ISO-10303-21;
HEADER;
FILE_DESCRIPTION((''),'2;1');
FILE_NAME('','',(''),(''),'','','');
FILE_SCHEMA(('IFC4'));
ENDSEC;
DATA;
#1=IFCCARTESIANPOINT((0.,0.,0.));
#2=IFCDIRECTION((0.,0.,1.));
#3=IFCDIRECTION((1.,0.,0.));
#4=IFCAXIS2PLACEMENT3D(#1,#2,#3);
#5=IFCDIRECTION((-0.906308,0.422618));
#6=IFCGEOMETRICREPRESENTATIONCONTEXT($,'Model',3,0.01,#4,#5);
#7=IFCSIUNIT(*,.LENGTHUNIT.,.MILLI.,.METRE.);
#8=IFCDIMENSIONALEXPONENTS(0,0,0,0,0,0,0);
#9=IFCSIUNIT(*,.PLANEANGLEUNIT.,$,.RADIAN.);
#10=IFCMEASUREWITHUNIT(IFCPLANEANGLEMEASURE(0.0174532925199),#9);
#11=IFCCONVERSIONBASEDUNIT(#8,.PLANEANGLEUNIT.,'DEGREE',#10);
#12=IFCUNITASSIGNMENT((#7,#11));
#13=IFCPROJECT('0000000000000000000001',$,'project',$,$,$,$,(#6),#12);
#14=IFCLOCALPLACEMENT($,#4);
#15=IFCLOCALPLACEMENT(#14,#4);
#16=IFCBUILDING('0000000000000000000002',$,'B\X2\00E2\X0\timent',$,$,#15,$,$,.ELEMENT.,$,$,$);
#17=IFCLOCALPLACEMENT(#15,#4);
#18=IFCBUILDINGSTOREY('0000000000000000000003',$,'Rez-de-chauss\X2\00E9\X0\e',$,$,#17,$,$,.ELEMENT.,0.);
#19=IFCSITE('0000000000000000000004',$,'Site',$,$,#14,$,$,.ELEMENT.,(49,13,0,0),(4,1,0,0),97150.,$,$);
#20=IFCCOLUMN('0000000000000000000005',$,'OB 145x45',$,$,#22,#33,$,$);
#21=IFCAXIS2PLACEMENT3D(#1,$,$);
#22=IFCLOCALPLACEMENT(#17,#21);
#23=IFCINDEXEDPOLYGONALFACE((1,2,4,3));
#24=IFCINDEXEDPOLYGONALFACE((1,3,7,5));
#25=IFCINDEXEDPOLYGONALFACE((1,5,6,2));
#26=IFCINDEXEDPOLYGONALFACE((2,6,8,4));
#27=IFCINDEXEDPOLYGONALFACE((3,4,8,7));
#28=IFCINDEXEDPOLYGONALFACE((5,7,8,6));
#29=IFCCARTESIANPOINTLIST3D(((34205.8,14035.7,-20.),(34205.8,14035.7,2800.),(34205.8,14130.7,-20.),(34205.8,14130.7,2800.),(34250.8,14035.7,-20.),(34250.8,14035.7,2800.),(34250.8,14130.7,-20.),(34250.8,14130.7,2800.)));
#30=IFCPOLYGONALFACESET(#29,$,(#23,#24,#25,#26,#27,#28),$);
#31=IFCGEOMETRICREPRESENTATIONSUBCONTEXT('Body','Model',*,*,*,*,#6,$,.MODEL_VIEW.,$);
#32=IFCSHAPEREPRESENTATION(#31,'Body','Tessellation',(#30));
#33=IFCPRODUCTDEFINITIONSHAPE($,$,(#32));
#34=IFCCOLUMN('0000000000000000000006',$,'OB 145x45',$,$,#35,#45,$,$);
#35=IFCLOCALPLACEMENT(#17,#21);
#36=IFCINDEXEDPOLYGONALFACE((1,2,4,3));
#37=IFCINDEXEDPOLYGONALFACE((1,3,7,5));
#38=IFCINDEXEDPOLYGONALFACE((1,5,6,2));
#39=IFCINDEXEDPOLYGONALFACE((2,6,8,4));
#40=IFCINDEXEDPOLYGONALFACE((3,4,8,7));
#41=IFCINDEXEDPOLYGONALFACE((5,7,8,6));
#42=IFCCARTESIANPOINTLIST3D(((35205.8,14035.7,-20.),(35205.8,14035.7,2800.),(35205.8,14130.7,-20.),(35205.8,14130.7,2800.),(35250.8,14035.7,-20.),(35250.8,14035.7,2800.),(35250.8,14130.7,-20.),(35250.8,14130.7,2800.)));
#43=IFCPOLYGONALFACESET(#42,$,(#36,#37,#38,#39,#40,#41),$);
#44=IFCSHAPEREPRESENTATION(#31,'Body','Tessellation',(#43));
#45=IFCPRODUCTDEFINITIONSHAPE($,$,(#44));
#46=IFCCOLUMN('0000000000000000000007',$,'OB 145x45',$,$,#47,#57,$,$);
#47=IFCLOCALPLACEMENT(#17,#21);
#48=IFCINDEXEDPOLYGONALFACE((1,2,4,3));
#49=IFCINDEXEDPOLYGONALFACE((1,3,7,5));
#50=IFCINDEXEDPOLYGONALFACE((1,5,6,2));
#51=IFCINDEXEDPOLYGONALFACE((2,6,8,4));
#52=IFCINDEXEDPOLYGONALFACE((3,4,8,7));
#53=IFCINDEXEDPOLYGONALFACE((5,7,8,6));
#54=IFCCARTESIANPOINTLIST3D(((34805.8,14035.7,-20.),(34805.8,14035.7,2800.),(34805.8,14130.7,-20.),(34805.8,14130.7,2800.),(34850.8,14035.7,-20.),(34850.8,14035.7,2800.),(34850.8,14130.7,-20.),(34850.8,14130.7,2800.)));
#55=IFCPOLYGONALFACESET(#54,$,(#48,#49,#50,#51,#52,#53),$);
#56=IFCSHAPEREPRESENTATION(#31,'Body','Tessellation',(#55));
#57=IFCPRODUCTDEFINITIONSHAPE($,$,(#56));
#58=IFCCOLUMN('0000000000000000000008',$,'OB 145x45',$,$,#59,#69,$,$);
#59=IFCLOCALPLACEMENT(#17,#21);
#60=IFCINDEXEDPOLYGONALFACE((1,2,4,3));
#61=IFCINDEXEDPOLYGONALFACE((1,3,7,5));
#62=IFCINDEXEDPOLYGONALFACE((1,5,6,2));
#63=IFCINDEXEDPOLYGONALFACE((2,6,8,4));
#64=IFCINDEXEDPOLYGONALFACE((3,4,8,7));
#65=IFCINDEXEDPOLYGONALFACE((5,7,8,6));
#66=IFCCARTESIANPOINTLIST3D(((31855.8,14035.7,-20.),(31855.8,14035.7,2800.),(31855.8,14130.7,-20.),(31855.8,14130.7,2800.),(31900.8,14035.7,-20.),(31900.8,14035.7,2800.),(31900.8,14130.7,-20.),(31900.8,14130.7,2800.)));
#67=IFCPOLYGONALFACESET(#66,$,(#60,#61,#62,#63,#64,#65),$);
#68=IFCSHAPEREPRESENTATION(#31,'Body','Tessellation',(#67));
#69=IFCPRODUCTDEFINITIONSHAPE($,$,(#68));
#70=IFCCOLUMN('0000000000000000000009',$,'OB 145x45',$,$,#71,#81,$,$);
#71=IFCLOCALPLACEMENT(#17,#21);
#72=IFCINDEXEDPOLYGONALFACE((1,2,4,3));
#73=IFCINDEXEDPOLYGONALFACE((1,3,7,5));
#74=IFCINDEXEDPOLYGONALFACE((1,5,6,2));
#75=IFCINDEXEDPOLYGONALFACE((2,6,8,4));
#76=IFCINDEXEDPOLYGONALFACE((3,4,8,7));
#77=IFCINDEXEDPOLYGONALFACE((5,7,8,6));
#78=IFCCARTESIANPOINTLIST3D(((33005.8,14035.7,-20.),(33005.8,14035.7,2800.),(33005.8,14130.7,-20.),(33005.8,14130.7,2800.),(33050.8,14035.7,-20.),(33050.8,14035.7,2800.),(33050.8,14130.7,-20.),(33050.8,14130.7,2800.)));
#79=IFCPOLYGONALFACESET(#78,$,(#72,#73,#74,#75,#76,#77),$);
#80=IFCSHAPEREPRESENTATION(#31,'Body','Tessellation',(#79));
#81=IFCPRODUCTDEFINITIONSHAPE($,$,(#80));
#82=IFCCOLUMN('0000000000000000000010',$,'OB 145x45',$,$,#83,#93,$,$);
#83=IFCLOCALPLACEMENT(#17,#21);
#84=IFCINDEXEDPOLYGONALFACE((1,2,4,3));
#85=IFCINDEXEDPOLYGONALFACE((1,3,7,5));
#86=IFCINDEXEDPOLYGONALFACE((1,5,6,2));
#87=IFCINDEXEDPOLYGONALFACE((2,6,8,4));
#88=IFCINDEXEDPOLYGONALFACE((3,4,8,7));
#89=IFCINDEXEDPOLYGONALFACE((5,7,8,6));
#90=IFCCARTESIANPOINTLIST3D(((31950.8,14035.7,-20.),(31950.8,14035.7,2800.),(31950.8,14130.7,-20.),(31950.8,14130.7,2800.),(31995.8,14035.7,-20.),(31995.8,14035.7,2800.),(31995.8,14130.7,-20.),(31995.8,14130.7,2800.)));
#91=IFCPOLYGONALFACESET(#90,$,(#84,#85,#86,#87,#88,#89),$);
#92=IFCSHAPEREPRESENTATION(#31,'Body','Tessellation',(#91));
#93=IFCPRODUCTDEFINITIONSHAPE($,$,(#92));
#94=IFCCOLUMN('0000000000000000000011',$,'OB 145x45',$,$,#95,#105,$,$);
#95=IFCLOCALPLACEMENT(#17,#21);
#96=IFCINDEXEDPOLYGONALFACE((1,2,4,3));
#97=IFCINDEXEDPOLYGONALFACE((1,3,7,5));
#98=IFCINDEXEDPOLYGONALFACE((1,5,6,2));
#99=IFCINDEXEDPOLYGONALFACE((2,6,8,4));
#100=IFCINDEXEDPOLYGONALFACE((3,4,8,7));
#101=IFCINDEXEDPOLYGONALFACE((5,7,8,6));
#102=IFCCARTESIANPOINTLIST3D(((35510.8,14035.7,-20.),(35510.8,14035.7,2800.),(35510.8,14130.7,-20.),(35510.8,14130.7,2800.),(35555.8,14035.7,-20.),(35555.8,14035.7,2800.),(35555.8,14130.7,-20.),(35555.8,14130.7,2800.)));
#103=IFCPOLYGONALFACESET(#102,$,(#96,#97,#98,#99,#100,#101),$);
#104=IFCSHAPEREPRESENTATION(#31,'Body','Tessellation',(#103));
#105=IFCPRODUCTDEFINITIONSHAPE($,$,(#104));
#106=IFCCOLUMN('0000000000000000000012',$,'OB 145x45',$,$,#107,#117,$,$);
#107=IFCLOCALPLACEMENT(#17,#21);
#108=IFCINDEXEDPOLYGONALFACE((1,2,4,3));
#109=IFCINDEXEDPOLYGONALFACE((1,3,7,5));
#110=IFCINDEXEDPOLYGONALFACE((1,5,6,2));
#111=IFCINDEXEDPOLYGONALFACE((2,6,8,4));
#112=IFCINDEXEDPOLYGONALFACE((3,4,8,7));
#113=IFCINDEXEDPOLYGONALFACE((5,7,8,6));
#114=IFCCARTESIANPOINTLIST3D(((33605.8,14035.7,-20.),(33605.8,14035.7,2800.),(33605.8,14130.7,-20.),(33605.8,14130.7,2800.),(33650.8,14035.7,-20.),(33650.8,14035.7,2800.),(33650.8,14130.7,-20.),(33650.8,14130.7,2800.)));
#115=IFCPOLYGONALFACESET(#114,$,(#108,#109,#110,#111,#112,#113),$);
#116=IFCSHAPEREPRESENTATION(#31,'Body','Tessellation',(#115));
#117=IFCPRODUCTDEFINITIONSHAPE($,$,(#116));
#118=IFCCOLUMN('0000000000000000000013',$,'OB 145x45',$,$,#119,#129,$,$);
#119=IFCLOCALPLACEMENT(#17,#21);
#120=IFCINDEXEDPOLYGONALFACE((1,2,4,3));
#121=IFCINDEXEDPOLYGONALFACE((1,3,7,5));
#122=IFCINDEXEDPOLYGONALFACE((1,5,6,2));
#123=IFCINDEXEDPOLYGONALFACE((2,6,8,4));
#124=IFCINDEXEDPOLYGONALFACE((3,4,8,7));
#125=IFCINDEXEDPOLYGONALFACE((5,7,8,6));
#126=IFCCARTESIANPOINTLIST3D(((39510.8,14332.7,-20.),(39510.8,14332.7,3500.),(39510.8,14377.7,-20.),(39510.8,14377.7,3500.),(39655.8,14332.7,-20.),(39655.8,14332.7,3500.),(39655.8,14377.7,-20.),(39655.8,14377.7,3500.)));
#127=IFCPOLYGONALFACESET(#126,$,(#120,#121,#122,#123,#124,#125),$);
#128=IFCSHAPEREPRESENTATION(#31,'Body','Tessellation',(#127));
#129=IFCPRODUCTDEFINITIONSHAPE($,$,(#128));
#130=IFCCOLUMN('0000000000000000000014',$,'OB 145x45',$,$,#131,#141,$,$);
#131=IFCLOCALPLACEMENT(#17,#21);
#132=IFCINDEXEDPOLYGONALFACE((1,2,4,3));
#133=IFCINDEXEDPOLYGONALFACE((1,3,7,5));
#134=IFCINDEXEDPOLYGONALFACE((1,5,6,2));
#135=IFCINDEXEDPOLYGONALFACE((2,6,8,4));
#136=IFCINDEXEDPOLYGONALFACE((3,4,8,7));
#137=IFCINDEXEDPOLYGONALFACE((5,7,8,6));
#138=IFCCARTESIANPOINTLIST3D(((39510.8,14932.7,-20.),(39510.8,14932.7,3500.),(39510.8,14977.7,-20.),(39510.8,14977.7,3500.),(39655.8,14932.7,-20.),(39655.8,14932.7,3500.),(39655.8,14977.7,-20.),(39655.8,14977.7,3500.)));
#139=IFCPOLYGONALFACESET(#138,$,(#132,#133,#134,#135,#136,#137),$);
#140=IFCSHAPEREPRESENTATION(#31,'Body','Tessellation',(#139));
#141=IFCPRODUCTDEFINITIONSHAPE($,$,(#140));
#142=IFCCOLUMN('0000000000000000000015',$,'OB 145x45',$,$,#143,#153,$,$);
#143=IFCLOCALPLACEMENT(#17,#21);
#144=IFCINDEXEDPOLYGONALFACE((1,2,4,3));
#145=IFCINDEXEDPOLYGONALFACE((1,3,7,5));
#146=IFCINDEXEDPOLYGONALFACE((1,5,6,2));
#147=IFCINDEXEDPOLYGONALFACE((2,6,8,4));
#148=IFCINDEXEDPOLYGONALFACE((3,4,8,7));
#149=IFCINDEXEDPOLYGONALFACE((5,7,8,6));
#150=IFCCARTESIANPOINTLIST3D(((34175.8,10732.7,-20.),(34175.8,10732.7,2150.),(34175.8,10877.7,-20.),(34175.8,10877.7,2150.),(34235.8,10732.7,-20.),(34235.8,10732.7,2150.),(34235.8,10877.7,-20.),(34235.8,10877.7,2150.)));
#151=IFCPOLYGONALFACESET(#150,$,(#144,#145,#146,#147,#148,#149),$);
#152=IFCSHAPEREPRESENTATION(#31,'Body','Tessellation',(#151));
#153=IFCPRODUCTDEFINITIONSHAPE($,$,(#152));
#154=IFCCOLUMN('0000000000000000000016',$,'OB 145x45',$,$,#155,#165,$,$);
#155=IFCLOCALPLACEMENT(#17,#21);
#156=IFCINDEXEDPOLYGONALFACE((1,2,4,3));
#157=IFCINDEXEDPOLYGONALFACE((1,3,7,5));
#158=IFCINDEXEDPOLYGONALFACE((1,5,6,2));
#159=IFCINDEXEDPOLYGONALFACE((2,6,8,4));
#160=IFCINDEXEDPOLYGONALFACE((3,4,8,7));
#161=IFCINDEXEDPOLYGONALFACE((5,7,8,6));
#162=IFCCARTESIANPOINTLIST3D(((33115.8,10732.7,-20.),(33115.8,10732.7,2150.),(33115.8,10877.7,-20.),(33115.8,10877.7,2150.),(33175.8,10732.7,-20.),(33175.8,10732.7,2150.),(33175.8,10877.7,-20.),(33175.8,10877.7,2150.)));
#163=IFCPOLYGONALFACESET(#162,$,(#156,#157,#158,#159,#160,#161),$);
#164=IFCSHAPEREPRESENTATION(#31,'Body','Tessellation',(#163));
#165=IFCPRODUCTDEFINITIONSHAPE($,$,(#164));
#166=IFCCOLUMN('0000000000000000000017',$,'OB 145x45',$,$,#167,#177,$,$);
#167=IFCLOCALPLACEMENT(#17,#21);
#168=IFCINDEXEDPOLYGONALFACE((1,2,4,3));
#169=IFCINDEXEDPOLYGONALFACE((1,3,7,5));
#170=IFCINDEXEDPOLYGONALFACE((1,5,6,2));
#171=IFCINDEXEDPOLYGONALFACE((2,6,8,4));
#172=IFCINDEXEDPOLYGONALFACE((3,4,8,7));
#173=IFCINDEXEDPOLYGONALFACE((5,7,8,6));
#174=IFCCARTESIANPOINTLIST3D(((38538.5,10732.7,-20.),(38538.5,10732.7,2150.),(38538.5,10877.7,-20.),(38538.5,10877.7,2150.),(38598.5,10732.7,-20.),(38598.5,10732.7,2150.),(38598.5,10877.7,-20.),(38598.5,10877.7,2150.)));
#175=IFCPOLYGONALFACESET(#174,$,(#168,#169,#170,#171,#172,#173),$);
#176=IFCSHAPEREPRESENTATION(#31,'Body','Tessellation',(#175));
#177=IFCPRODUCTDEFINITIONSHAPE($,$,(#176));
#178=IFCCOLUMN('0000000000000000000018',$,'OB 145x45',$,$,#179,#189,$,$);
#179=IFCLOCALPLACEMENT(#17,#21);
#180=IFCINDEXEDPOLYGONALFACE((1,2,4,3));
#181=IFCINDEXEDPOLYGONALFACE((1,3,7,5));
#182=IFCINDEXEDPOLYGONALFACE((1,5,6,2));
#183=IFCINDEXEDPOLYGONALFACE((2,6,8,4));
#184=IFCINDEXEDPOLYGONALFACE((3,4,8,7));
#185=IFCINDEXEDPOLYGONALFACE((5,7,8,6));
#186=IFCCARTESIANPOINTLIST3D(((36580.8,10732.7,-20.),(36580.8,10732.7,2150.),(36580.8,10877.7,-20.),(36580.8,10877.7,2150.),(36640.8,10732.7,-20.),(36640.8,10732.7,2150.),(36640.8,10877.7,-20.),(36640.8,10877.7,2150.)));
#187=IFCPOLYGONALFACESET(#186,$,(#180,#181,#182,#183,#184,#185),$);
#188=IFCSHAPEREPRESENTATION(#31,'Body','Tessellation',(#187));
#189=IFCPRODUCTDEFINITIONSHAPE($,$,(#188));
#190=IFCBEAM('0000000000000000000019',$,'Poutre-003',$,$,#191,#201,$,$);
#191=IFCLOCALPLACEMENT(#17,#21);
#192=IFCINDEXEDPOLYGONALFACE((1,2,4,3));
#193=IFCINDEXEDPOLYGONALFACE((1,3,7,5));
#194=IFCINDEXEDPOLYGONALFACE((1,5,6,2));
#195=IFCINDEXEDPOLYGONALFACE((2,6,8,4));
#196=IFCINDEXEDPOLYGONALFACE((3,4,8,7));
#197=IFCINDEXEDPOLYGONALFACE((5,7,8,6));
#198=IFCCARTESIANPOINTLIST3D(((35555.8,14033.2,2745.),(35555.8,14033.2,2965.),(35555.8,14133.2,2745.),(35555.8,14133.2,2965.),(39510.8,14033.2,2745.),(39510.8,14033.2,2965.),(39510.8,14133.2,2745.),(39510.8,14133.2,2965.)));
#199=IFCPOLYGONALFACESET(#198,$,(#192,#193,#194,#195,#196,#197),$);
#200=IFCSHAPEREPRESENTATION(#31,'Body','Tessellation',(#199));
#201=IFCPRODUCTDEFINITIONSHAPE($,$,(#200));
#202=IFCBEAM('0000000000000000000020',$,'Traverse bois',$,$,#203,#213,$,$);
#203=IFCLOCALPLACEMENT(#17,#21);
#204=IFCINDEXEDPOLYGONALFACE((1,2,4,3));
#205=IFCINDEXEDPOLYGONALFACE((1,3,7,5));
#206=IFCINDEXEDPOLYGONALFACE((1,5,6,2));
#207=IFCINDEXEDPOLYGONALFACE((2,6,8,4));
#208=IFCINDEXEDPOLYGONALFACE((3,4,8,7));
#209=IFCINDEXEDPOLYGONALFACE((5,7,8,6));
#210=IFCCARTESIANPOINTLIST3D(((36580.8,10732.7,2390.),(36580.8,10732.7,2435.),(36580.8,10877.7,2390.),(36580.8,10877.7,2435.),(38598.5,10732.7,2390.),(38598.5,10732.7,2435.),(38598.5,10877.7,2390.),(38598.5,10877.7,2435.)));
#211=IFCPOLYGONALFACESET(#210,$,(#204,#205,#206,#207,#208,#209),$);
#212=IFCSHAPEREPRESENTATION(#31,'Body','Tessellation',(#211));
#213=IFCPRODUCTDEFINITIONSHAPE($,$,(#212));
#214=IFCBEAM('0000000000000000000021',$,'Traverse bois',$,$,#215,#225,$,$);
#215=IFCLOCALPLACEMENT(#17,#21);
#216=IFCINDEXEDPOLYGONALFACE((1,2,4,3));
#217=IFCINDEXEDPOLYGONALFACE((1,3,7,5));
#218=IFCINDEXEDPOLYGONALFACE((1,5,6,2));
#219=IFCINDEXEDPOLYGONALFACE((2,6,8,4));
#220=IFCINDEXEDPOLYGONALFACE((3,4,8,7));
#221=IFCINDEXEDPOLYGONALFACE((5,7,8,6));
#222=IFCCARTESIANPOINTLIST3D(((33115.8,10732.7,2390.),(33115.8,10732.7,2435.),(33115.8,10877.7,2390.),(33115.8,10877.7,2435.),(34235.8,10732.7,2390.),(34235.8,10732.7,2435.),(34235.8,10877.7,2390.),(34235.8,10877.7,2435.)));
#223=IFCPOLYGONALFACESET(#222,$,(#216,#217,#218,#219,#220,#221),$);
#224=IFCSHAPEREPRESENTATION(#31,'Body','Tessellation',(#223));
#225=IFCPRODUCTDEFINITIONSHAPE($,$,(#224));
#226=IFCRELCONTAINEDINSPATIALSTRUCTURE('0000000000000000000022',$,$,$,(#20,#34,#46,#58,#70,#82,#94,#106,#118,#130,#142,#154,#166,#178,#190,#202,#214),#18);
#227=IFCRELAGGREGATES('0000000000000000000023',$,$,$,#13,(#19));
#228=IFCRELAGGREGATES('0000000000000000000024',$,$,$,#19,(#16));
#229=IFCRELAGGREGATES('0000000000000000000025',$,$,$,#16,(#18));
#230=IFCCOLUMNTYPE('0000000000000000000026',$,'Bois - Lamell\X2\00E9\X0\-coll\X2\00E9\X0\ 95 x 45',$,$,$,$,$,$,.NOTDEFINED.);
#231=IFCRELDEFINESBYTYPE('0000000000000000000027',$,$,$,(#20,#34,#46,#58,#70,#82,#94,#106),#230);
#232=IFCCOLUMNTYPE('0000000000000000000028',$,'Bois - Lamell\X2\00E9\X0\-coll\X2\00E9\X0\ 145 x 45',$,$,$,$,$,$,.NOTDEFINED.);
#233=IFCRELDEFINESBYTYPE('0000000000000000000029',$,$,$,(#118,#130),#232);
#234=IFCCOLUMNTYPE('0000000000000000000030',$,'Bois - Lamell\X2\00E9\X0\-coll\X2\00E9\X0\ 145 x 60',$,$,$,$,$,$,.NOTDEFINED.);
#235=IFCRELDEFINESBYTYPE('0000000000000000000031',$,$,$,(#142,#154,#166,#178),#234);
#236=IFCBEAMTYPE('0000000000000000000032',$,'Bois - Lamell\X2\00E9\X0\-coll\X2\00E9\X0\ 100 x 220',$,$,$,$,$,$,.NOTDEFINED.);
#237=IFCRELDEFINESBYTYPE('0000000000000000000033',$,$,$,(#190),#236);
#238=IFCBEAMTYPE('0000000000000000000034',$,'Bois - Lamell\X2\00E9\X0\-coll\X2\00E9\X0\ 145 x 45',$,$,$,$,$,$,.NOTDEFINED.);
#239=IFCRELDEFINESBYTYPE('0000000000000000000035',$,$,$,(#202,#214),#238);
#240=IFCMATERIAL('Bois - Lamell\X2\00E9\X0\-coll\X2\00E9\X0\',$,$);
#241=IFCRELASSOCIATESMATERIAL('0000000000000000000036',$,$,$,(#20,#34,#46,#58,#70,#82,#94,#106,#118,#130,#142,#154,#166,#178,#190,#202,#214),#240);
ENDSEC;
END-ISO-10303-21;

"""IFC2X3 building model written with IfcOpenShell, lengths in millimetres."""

from ifc_helpers import new_model, entity, si_unit, converted_unit, direction, frame, frame_2d, origin_with_axes, origin_2d_with_axis, place, context, subcontext, project, spatial, rectangle, extrude, material, type_object, element, save


model = new_model("IFC2X3")

# Units and contexts
model_context = context("Model", 3, precision=0.01, world=origin_with_axes(), true_north=direction((-0.906308, 0.422618)))
body_context = subcontext(model_context, "Body", "Model", "MODEL_VIEW")
ifc_project = project(units=[si_unit("LENGTHUNIT", "METRE", prefix="MILLI"), converted_unit("PLANEANGLEUNIT", "DEGREE", entity("IfcPlaneAngleMeasure", 0.0174532925199), si_unit("PLANEANGLEUNIT", "RADIAN"), dimensions=[0, 0, 0, 0, 0, 0, 0])], contexts=[model_context])

# Site, building, storey
site_placement = place(None, origin_with_axes())
site = spatial("IfcSite", under=ifc_project, at=site_placement, Name="Site", CompositionType="ELEMENT", RefLatitude=(49, 13, 0, 0), RefLongitude=(4, 1, 0, 0), RefElevation=97150.0)
building_placement = place(site_placement, origin_with_axes())
building = spatial("IfcBuilding", under=site, at=building_placement, Name="Bâtiment", CompositionType="ELEMENT")
storey_placement = place(building_placement, origin_with_axes())
storey = spatial("IfcBuildingStorey", under=building, at=storey_placement, Name="Rez-de-chaussée", CompositionType="ELEMENT", Elevation=0.0)

# Columns
ifc_material_1 = material(Name="Bois - Lamellé-collé")
column_type_1 = type_object("IfcColumnType", Name="Bois - Lamellé-collé 95 x 45", PredefinedType="NOTDEFINED")
for number, where, z_axis, x_axis, name in (
    (1, (34228.3, 14083.2, -20.0), (0.0, 0.0, 1.0), (0.0, -1.0, 0.0), "OB 145x45"),
    (2, (35228.3, 14083.2, -20.0), (0.0, 0.0, 1.0), (0.0, -1.0, 0.0), "OB 145x45"),
    (3, (34828.3, 14083.2, -20.0), (0.0, 0.0, 1.0), (0.0, -1.0, 0.0), "OB 145x45"),
    (4, (31878.3, 14083.2, -20.0), (0.0, 0.0, 1.0), (0.0, -1.0, 0.0), "OB 145x45"),
    (5, (33028.3, 14083.2, -20.0), (0.0, 0.0, 1.0), (0.0, -1.0, 0.0), "OB 145x45"),
    (6, (31973.3, 14083.2, -20.0), (0.0, 0.0, 1.0), (0.0, -1.0, 0.0), "OB 145x45"),
    (7, (35533.3, 14083.2, -20.0), (0.0, 0.0, 1.0), (0.0, -1.0, 0.0), "OB 145x45"),
    (8, (33628.3, 14083.2, -20.0), (0.0, 0.0, 1.0), (0.0, -1.0, 0.0), "OB 145x45"),
):
    element("IfcColumn", number, at=place(storey_placement, frame(where, z_axis=z_axis, x_axis=x_axis)), inside=storey, type_object=column_type_1, material=ifc_material_1, Name=name, context=body_context, shape_type="SweptSolid", body=[
        extrude(rectangle(XDim=95.0, YDim=45.0, at=origin_2d_with_axis()), origin_with_axes(), (0.0, 0.0, 1.0), 2820.0),
    ])
column_type_2 = type_object("IfcColumnType", Name="Bois - Lamellé-collé 145 x 45", PredefinedType="NOTDEFINED")
for number, where, z_axis, x_axis, name in (
    (9, (39583.3, 14355.2, -20.0), (0.0, 0.0, 1.0), (-1.0, 0.0, 0.0), "OB 145x45"),
    (10, (39583.3, 14955.2, -20.0), (0.0, 0.0, 1.0), (-1.0, 0.0, 0.0), "OB 145x45"),
):
    element("IfcColumn", number, at=place(storey_placement, frame(where, z_axis=z_axis, x_axis=x_axis)), inside=storey, type_object=column_type_2, material=ifc_material_1, Name=name, context=body_context, shape_type="SweptSolid", body=[
        extrude(rectangle(XDim=145.0, YDim=45.0, at=origin_2d_with_axis()), frame((0.0, 0.0, 0.0), z_axis=(0.0, 0.0, -1.0), x_axis=(-1.0, 0.0, 0.0)), (0.0, 0.0, -1.0), 3520.0),
    ])
column_type_3 = type_object("IfcColumnType", Name="Bois - Lamellé-collé 145 x 60", PredefinedType="NOTDEFINED")
for number, where, z_axis, x_axis, name in (
    (11, (34205.8, 10805.2, -20.0), (0.0, 0.0, 1.0), (0.0, 1.0, 0.0), "OB 145x45"),
    (12, (33145.8, 10805.2, -20.0), (0.0, 0.0, 1.0), (0.0, 1.0, 0.0), "OB 145x45"),
    (13, (38568.5, 10805.2, -20.0), (0.0, 0.0, 1.0), (0.0, 1.0, 0.0), "OB 145x45"),
    (14, (36610.8, 10805.2, -20.0), (0.0, 0.0, 1.0), (0.0, 1.0, 0.0), "OB 145x45"),
):
    element("IfcColumn", number, at=place(storey_placement, frame(where, z_axis=z_axis, x_axis=x_axis)), inside=storey, type_object=column_type_3, material=ifc_material_1, Name=name, context=body_context, shape_type="SweptSolid", body=[
        extrude(rectangle(XDim=145.0, YDim=60.0, at=origin_2d_with_axis()), frame((0.0, 0.0, 0.0), z_axis=(0.0, 0.0, -1.0), x_axis=(-1.0, 0.0, 0.0)), (0.0, 0.0, -1.0), 2170.0),
    ])

# Beams
beam_type_1 = type_object("IfcBeamType", Name="Bois - Lamellé-collé 100 x 220", PredefinedType="NOTDEFINED")
beam_1_placement = place(storey_placement, frame((35555.8, 14083.2, 2965.0), z_axis=(0.0, 0.0, 1.0), x_axis=(0.0, -1.0, 0.0)))
element("IfcBeam", 15, at=beam_1_placement, inside=storey, type_object=beam_type_1, material=ifc_material_1, Name="Poutre-003", context=body_context, shape_type="SweptSolid", body=[
    extrude(rectangle(XDim=220.0, YDim=100.0, at=frame_2d((-110.0, 0.0), x_axis=(1.0, 0.0))), frame((0.0, 0.0, 0.0), z_axis=(0.0, 1.0, 0.0), x_axis=(0.0, 0.0, 1.0)), (0.0, 0.0, 1.0), 3955.0),
])
beam_type_2 = type_object("IfcBeamType", Name="Bois - Lamellé-collé 145 x 45", PredefinedType="NOTDEFINED")
beam_2_placement = place(storey_placement, frame((36580.8, 10805.2, 2435.0), z_axis=(0.0, 0.0, 1.0), x_axis=(0.0, -1.0, 0.0)))
element("IfcBeam", 16, at=beam_2_placement, inside=storey, type_object=beam_type_2, material=ifc_material_1, Name="Traverse bois", context=body_context, shape_type="SweptSolid", body=[
    extrude(rectangle(XDim=45.0, YDim=145.0, at=frame_2d((-22.5, 0.0), x_axis=(1.0, 0.0))), frame((0.0, 0.0, 0.0), z_axis=(0.0, 1.0, 0.0), x_axis=(0.0, 0.0, 1.0)), (0.0, 0.0, 1.0), 2017.7),
])
beam_3_placement = place(storey_placement, frame((33115.8, 10805.2, 2435.0), z_axis=(0.0, 0.0, 1.0), x_axis=(0.0, -1.0, 0.0)))
element("IfcBeam", 17, at=beam_3_placement, inside=storey, type_object=beam_type_2, material=ifc_material_1, Name="Traverse bois", context=body_context, shape_type="SweptSolid", body=[
    extrude(rectangle(XDim=45.0, YDim=145.0, at=frame_2d((-22.5, 0.0), x_axis=(1.0, 0.0))), frame((0.0, 0.0, 0.0), z_axis=(0.0, 1.0, 0.0), x_axis=(0.0, 0.0, 1.0)), (0.0, 0.0, 1.0), 1120.0),
])

save(model, "model.ifc")
